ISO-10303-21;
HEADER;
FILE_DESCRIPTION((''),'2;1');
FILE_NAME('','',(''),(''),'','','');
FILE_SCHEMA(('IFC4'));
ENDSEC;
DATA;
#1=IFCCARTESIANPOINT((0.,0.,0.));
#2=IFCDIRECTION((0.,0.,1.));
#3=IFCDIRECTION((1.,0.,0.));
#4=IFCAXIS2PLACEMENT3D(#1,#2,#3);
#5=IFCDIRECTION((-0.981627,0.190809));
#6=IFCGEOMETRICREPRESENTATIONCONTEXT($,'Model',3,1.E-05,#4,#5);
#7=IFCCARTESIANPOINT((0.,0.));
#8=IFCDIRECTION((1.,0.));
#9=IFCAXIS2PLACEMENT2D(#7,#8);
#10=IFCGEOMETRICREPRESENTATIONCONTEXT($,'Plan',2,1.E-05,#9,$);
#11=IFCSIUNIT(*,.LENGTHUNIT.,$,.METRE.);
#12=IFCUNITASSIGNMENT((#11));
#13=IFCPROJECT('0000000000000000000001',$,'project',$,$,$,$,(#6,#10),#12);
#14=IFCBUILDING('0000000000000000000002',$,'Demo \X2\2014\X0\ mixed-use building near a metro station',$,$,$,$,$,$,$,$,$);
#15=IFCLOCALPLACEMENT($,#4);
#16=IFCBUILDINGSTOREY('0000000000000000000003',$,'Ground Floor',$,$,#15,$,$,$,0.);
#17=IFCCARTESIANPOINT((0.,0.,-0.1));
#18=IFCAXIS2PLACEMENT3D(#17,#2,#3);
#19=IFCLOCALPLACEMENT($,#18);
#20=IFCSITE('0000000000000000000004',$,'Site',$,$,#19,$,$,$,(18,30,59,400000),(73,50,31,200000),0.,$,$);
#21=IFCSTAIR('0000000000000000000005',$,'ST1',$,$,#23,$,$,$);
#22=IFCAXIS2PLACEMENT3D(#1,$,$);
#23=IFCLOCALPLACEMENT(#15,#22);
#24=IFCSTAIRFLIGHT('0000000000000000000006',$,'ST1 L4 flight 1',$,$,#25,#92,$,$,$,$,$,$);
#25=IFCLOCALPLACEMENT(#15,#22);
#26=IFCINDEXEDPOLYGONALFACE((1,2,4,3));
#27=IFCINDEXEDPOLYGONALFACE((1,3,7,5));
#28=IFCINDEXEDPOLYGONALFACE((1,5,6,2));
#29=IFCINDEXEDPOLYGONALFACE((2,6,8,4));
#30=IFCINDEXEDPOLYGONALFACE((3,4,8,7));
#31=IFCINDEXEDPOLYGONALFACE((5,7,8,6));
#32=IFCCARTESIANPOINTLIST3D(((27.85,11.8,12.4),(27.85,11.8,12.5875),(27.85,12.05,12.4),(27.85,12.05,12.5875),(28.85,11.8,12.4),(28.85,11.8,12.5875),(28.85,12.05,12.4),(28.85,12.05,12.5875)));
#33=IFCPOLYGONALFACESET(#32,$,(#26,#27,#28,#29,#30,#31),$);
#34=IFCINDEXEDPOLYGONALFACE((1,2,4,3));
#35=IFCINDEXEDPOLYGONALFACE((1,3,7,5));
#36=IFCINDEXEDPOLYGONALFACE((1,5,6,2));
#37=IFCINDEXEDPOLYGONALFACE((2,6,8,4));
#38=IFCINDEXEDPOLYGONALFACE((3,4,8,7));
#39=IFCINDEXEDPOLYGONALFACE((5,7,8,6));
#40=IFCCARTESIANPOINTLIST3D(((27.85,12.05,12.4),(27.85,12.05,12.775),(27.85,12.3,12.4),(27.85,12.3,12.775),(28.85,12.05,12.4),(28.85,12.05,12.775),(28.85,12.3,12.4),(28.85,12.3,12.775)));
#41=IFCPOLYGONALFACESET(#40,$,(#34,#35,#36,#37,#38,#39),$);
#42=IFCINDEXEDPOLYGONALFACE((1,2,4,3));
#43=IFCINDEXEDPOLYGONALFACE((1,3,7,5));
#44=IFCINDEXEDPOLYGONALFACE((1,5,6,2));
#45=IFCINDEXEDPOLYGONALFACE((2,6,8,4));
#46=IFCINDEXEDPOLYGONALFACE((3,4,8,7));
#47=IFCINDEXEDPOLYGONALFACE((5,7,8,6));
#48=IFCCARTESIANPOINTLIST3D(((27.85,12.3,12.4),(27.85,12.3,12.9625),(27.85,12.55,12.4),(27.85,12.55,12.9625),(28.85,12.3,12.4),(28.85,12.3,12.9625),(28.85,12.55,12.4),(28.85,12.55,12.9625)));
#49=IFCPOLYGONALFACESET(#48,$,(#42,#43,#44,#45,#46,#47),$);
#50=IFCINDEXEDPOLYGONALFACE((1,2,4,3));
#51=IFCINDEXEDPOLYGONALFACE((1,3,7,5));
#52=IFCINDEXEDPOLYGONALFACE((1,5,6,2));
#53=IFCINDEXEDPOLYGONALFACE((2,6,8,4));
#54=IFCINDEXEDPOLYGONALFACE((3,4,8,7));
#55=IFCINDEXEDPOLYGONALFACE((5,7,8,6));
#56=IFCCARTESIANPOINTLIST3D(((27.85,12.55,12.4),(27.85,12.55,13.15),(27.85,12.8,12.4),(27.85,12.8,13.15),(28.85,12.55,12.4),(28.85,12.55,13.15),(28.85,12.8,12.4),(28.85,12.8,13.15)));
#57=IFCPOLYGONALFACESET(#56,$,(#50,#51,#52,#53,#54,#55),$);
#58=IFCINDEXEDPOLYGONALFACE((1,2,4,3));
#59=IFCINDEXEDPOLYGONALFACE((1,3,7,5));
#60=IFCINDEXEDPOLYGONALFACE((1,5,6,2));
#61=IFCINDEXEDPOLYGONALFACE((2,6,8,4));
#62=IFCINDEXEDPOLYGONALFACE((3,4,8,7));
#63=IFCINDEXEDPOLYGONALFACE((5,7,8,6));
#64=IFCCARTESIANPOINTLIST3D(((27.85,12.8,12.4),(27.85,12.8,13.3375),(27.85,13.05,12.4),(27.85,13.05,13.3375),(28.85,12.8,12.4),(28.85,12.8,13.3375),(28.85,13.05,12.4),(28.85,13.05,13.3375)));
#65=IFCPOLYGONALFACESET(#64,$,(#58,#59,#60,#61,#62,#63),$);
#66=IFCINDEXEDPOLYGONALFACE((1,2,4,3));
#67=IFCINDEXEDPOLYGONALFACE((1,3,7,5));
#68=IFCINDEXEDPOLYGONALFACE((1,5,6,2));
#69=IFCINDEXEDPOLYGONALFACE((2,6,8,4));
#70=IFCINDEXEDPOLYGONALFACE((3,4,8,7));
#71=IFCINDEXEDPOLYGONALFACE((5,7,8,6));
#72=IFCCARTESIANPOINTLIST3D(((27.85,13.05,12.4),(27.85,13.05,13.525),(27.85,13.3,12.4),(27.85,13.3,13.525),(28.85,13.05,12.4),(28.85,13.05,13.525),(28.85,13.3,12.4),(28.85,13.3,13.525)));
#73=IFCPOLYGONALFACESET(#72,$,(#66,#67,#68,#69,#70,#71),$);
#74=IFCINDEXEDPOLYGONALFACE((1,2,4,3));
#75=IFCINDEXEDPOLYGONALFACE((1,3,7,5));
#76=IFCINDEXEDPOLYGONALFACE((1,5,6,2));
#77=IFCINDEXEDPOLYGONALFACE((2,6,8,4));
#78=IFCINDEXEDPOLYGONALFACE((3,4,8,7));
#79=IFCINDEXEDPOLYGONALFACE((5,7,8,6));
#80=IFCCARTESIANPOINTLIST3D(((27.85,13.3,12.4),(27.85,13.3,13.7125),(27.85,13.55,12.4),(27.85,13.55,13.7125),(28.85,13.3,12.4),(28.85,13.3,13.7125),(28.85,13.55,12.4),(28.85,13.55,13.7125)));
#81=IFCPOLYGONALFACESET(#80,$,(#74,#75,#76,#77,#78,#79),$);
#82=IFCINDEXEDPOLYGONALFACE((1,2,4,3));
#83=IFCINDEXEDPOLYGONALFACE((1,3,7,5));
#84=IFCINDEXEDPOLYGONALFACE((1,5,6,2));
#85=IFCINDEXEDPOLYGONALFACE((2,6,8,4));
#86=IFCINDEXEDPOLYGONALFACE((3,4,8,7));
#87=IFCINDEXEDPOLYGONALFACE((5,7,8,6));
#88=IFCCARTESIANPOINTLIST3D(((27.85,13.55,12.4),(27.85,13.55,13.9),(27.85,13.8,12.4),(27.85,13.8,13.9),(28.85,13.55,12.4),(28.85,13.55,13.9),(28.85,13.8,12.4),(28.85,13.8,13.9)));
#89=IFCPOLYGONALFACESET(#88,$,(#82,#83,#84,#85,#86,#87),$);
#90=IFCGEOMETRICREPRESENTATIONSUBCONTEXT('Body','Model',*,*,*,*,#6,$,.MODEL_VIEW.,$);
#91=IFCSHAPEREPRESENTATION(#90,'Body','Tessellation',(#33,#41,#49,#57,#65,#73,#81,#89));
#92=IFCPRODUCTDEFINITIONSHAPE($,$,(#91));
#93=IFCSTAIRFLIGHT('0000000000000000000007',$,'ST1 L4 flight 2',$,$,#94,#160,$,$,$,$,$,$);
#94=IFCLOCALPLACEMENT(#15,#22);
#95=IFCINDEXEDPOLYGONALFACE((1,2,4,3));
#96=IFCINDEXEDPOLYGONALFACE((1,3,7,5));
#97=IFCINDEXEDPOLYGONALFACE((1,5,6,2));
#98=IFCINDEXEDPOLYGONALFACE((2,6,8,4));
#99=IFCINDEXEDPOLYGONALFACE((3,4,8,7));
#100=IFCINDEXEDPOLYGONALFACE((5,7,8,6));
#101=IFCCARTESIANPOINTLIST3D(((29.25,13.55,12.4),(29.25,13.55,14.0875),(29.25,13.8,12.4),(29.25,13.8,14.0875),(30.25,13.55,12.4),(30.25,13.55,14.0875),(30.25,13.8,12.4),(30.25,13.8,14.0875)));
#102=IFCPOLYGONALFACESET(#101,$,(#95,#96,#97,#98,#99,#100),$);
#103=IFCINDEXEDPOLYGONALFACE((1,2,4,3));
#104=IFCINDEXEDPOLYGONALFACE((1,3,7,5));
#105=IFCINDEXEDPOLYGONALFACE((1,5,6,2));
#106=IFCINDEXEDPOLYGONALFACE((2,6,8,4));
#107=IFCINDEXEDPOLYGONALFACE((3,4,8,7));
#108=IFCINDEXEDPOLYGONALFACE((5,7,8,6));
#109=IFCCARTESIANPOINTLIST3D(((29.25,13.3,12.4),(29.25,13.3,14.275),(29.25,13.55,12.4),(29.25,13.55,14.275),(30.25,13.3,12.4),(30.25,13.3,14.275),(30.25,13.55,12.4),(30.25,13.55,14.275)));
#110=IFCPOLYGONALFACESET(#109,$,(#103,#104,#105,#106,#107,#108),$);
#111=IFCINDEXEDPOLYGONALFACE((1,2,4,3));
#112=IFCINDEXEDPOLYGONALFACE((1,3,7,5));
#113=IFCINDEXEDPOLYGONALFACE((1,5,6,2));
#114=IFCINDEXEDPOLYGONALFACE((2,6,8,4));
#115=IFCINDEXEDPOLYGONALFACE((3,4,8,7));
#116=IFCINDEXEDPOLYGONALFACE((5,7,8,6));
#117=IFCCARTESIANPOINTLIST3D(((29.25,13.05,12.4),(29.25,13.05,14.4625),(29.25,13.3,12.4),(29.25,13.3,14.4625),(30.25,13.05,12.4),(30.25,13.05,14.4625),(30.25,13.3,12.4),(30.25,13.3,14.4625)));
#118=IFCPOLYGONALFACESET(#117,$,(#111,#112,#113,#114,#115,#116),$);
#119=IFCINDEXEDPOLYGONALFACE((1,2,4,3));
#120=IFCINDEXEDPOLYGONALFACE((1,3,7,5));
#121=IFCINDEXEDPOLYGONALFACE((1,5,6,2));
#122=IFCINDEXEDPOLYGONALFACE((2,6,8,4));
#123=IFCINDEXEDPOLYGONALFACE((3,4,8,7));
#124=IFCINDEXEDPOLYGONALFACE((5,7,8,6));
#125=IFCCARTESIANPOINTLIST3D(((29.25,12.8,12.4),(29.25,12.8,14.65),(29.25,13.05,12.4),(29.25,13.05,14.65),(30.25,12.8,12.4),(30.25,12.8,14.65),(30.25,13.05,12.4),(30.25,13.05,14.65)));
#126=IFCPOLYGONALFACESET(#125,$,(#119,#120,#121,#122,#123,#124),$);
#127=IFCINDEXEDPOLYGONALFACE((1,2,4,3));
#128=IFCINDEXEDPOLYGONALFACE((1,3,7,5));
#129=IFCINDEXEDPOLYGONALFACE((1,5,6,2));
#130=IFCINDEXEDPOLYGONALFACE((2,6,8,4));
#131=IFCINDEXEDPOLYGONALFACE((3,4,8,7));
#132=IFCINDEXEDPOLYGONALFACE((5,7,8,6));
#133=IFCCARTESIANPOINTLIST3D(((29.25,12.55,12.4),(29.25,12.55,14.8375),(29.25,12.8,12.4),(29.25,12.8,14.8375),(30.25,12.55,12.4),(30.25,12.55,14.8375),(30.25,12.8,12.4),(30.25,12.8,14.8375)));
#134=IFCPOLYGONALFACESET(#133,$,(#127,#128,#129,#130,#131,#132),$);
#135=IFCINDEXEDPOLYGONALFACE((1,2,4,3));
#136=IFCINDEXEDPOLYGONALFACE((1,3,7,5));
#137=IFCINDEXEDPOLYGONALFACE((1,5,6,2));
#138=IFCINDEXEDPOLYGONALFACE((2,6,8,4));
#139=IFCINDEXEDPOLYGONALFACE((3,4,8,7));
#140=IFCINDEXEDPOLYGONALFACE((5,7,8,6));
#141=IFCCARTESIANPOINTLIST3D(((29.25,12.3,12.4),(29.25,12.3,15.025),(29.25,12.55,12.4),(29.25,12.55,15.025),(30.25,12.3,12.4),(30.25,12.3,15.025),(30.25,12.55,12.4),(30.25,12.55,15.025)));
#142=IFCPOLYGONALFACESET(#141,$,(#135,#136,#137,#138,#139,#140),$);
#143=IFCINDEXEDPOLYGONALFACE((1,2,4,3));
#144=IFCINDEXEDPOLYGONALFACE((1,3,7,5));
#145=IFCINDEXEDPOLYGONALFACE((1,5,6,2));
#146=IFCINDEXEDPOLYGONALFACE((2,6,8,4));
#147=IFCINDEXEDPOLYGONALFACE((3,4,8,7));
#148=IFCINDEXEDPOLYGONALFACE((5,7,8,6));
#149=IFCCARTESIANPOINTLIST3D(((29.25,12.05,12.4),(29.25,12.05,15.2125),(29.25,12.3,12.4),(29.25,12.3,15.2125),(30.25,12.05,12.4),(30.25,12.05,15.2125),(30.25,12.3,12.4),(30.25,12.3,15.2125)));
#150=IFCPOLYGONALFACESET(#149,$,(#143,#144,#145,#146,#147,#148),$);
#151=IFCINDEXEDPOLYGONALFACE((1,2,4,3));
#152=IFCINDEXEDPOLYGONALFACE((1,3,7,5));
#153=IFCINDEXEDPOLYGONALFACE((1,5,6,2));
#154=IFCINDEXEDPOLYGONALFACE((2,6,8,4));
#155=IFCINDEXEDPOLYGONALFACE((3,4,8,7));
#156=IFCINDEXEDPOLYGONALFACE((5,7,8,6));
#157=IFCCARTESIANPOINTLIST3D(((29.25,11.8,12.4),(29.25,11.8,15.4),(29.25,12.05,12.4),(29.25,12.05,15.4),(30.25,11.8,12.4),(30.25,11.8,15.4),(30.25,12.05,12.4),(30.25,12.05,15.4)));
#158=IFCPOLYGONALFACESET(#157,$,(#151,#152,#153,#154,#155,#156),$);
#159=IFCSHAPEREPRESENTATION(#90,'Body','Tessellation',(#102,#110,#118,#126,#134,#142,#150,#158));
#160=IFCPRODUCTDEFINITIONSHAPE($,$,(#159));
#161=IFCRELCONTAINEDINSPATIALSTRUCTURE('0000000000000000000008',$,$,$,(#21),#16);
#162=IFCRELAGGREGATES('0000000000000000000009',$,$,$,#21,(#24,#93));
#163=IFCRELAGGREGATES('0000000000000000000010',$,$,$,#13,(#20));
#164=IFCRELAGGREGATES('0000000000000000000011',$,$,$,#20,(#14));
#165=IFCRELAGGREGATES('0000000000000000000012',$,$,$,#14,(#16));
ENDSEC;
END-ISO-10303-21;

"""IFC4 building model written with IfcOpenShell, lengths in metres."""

from ifc_helpers import new_model, si_unit, direction, frame, origin_with_axes, origin_2d_with_axis, place, context, subcontext, project, spatial, line, indexed_curve, outline, extrude, element, aggregate, save


model = new_model("IFC4")

# Units and contexts
model_context = context("Model", 3, precision=1e-05, world=origin_with_axes(), true_north=direction((-0.981627, 0.190809)))
plan_context = context("Plan", 2, precision=1e-05, world=origin_2d_with_axis())
body_context = subcontext(model_context, "Body", "Model", "MODEL_VIEW")
ifc_project = project(units=[si_unit("LENGTHUNIT", "METRE")], contexts=[model_context, plan_context])

# Site, building, storey
site_placement = place(None, frame((0.0, 0.0, -0.1), z_axis=(0.0, 0.0, 1.0), x_axis=(1.0, 0.0, 0.0)))
site = spatial("IfcSite", under=ifc_project, at=site_placement, Name="Site", RefLatitude=(18, 30, 59, 400000), RefLongitude=(73, 50, 31, 200000), RefElevation=0.0)
building = spatial("IfcBuilding", under=site, Name="Demo — mixed-use building near a metro station")
storey_placement = place(None, origin_with_axes())
storey = spatial("IfcBuildingStorey", under=building, at=storey_placement, Name="Ground Floor", Elevation=0.0)

# Stair, stair flights
stair = element("IfcStair", 1, inside=storey, Name="ST1")
stair_flight_1_placement = place(None, origin_with_axes())
stair_flight_1 = element("IfcStairFlight", 2, at=stair_flight_1_placement, Name="ST1 L4 flight 1", context=body_context, shape_type="SweptSolid", body=[
    extrude(outline(indexed_curve([(27.85, 11.8), (28.85, 11.8), (28.85, 12.05), (27.85, 12.05)], segments=[line(1, 2, 3, 4, 1)])), frame((0.0, 0.0, 12.4), z_axis=(0.0, 0.0, 1.0), x_axis=(1.0, 0.0, 0.0)), (0.0, 0.0, 1.0), 0.1875),
    extrude(outline(indexed_curve([(27.85, 12.05), (28.85, 12.05), (28.85, 12.3), (27.85, 12.3)], segments=[line(1, 2, 3, 4, 1)])), frame((0.0, 0.0, 12.4), z_axis=(0.0, 0.0, 1.0), x_axis=(1.0, 0.0, 0.0)), (0.0, 0.0, 1.0), 0.375),
    extrude(outline(indexed_curve([(27.85, 12.3), (28.85, 12.3), (28.85, 12.55), (27.85, 12.55)], segments=[line(1, 2, 3, 4, 1)])), frame((0.0, 0.0, 12.4), z_axis=(0.0, 0.0, 1.0), x_axis=(1.0, 0.0, 0.0)), (0.0, 0.0, 1.0), 0.5625),
    extrude(outline(indexed_curve([(27.85, 12.55), (28.85, 12.55), (28.85, 12.8), (27.85, 12.8)], segments=[line(1, 2, 3, 4, 1)])), frame((0.0, 0.0, 12.4), z_axis=(0.0, 0.0, 1.0), x_axis=(1.0, 0.0, 0.0)), (0.0, 0.0, 1.0), 0.75),
    extrude(outline(indexed_curve([(27.85, 12.8), (28.85, 12.8), (28.85, 13.05), (27.85, 13.05)], segments=[line(1, 2, 3, 4, 1)])), frame((0.0, 0.0, 12.4), z_axis=(0.0, 0.0, 1.0), x_axis=(1.0, 0.0, 0.0)), (0.0, 0.0, 1.0), 0.9375),
    extrude(outline(indexed_curve([(27.85, 13.05), (28.85, 13.05), (28.85, 13.3), (27.85, 13.3)], segments=[line(1, 2, 3, 4, 1)])), frame((0.0, 0.0, 12.4), z_axis=(0.0, 0.0, 1.0), x_axis=(1.0, 0.0, 0.0)), (0.0, 0.0, 1.0), 1.125),
    extrude(outline(indexed_curve([(27.85, 13.3), (28.85, 13.3), (28.85, 13.55), (27.85, 13.55)], segments=[line(1, 2, 3, 4, 1)])), frame((0.0, 0.0, 12.4), z_axis=(0.0, 0.0, 1.0), x_axis=(1.0, 0.0, 0.0)), (0.0, 0.0, 1.0), 1.3125),
    extrude(outline(indexed_curve([(27.85, 13.55), (28.85, 13.55), (28.85, 13.8), (27.85, 13.8)], segments=[line(1, 2, 3, 4, 1)])), frame((0.0, 0.0, 12.4), z_axis=(0.0, 0.0, 1.0), x_axis=(1.0, 0.0, 0.0)), (0.0, 0.0, 1.0), 1.5),
])
stair_flight_2_placement = place(None, origin_with_axes())
stair_flight_2 = element("IfcStairFlight", 3, at=stair_flight_2_placement, Name="ST1 L4 flight 2", context=body_context, shape_type="SweptSolid", body=[
    extrude(outline(indexed_curve([(29.25, 13.55), (30.25, 13.55), (30.25, 13.8), (29.25, 13.8)], segments=[line(1, 2, 3, 4, 1)])), frame((0.0, 0.0, 12.4), z_axis=(0.0, 0.0, 1.0), x_axis=(1.0, 0.0, 0.0)), (0.0, 0.0, 1.0), 1.6875),
    extrude(outline(indexed_curve([(29.25, 13.3), (30.25, 13.3), (30.25, 13.55), (29.25, 13.55)], segments=[line(1, 2, 3, 4, 1)])), frame((0.0, 0.0, 12.4), z_axis=(0.0, 0.0, 1.0), x_axis=(1.0, 0.0, 0.0)), (0.0, 0.0, 1.0), 1.875),
    extrude(outline(indexed_curve([(29.25, 13.05), (30.25, 13.05), (30.25, 13.3), (29.25, 13.3)], segments=[line(1, 2, 3, 4, 1)])), frame((0.0, 0.0, 12.4), z_axis=(0.0, 0.0, 1.0), x_axis=(1.0, 0.0, 0.0)), (0.0, 0.0, 1.0), 2.0625),
    extrude(outline(indexed_curve([(29.25, 12.8), (30.25, 12.8), (30.25, 13.05), (29.25, 13.05)], segments=[line(1, 2, 3, 4, 1)])), frame((0.0, 0.0, 12.4), z_axis=(0.0, 0.0, 1.0), x_axis=(1.0, 0.0, 0.0)), (0.0, 0.0, 1.0), 2.25),
    extrude(outline(indexed_curve([(29.25, 12.55), (30.25, 12.55), (30.25, 12.8), (29.25, 12.8)], segments=[line(1, 2, 3, 4, 1)])), frame((0.0, 0.0, 12.4), z_axis=(0.0, 0.0, 1.0), x_axis=(1.0, 0.0, 0.0)), (0.0, 0.0, 1.0), 2.4375),
    extrude(outline(indexed_curve([(29.25, 12.3), (30.25, 12.3), (30.25, 12.55), (29.25, 12.55)], segments=[line(1, 2, 3, 4, 1)])), frame((0.0, 0.0, 12.4), z_axis=(0.0, 0.0, 1.0), x_axis=(1.0, 0.0, 0.0)), (0.0, 0.0, 1.0), 2.625),
    extrude(outline(indexed_curve([(29.25, 12.05), (30.25, 12.05), (30.25, 12.3), (29.25, 12.3)], segments=[line(1, 2, 3, 4, 1)])), frame((0.0, 0.0, 12.4), z_axis=(0.0, 0.0, 1.0), x_axis=(1.0, 0.0, 0.0)), (0.0, 0.0, 1.0), 2.8125),
    extrude(outline(indexed_curve([(29.25, 11.8), (30.25, 11.8), (30.25, 12.05), (29.25, 12.05)], segments=[line(1, 2, 3, 4, 1)])), frame((0.0, 0.0, 12.4), z_axis=(0.0, 0.0, 1.0), x_axis=(1.0, 0.0, 0.0)), (0.0, 0.0, 1.0), 3.0),
])
aggregate(stair, [stair_flight_1, stair_flight_2])

save(model, "model.ifc")
